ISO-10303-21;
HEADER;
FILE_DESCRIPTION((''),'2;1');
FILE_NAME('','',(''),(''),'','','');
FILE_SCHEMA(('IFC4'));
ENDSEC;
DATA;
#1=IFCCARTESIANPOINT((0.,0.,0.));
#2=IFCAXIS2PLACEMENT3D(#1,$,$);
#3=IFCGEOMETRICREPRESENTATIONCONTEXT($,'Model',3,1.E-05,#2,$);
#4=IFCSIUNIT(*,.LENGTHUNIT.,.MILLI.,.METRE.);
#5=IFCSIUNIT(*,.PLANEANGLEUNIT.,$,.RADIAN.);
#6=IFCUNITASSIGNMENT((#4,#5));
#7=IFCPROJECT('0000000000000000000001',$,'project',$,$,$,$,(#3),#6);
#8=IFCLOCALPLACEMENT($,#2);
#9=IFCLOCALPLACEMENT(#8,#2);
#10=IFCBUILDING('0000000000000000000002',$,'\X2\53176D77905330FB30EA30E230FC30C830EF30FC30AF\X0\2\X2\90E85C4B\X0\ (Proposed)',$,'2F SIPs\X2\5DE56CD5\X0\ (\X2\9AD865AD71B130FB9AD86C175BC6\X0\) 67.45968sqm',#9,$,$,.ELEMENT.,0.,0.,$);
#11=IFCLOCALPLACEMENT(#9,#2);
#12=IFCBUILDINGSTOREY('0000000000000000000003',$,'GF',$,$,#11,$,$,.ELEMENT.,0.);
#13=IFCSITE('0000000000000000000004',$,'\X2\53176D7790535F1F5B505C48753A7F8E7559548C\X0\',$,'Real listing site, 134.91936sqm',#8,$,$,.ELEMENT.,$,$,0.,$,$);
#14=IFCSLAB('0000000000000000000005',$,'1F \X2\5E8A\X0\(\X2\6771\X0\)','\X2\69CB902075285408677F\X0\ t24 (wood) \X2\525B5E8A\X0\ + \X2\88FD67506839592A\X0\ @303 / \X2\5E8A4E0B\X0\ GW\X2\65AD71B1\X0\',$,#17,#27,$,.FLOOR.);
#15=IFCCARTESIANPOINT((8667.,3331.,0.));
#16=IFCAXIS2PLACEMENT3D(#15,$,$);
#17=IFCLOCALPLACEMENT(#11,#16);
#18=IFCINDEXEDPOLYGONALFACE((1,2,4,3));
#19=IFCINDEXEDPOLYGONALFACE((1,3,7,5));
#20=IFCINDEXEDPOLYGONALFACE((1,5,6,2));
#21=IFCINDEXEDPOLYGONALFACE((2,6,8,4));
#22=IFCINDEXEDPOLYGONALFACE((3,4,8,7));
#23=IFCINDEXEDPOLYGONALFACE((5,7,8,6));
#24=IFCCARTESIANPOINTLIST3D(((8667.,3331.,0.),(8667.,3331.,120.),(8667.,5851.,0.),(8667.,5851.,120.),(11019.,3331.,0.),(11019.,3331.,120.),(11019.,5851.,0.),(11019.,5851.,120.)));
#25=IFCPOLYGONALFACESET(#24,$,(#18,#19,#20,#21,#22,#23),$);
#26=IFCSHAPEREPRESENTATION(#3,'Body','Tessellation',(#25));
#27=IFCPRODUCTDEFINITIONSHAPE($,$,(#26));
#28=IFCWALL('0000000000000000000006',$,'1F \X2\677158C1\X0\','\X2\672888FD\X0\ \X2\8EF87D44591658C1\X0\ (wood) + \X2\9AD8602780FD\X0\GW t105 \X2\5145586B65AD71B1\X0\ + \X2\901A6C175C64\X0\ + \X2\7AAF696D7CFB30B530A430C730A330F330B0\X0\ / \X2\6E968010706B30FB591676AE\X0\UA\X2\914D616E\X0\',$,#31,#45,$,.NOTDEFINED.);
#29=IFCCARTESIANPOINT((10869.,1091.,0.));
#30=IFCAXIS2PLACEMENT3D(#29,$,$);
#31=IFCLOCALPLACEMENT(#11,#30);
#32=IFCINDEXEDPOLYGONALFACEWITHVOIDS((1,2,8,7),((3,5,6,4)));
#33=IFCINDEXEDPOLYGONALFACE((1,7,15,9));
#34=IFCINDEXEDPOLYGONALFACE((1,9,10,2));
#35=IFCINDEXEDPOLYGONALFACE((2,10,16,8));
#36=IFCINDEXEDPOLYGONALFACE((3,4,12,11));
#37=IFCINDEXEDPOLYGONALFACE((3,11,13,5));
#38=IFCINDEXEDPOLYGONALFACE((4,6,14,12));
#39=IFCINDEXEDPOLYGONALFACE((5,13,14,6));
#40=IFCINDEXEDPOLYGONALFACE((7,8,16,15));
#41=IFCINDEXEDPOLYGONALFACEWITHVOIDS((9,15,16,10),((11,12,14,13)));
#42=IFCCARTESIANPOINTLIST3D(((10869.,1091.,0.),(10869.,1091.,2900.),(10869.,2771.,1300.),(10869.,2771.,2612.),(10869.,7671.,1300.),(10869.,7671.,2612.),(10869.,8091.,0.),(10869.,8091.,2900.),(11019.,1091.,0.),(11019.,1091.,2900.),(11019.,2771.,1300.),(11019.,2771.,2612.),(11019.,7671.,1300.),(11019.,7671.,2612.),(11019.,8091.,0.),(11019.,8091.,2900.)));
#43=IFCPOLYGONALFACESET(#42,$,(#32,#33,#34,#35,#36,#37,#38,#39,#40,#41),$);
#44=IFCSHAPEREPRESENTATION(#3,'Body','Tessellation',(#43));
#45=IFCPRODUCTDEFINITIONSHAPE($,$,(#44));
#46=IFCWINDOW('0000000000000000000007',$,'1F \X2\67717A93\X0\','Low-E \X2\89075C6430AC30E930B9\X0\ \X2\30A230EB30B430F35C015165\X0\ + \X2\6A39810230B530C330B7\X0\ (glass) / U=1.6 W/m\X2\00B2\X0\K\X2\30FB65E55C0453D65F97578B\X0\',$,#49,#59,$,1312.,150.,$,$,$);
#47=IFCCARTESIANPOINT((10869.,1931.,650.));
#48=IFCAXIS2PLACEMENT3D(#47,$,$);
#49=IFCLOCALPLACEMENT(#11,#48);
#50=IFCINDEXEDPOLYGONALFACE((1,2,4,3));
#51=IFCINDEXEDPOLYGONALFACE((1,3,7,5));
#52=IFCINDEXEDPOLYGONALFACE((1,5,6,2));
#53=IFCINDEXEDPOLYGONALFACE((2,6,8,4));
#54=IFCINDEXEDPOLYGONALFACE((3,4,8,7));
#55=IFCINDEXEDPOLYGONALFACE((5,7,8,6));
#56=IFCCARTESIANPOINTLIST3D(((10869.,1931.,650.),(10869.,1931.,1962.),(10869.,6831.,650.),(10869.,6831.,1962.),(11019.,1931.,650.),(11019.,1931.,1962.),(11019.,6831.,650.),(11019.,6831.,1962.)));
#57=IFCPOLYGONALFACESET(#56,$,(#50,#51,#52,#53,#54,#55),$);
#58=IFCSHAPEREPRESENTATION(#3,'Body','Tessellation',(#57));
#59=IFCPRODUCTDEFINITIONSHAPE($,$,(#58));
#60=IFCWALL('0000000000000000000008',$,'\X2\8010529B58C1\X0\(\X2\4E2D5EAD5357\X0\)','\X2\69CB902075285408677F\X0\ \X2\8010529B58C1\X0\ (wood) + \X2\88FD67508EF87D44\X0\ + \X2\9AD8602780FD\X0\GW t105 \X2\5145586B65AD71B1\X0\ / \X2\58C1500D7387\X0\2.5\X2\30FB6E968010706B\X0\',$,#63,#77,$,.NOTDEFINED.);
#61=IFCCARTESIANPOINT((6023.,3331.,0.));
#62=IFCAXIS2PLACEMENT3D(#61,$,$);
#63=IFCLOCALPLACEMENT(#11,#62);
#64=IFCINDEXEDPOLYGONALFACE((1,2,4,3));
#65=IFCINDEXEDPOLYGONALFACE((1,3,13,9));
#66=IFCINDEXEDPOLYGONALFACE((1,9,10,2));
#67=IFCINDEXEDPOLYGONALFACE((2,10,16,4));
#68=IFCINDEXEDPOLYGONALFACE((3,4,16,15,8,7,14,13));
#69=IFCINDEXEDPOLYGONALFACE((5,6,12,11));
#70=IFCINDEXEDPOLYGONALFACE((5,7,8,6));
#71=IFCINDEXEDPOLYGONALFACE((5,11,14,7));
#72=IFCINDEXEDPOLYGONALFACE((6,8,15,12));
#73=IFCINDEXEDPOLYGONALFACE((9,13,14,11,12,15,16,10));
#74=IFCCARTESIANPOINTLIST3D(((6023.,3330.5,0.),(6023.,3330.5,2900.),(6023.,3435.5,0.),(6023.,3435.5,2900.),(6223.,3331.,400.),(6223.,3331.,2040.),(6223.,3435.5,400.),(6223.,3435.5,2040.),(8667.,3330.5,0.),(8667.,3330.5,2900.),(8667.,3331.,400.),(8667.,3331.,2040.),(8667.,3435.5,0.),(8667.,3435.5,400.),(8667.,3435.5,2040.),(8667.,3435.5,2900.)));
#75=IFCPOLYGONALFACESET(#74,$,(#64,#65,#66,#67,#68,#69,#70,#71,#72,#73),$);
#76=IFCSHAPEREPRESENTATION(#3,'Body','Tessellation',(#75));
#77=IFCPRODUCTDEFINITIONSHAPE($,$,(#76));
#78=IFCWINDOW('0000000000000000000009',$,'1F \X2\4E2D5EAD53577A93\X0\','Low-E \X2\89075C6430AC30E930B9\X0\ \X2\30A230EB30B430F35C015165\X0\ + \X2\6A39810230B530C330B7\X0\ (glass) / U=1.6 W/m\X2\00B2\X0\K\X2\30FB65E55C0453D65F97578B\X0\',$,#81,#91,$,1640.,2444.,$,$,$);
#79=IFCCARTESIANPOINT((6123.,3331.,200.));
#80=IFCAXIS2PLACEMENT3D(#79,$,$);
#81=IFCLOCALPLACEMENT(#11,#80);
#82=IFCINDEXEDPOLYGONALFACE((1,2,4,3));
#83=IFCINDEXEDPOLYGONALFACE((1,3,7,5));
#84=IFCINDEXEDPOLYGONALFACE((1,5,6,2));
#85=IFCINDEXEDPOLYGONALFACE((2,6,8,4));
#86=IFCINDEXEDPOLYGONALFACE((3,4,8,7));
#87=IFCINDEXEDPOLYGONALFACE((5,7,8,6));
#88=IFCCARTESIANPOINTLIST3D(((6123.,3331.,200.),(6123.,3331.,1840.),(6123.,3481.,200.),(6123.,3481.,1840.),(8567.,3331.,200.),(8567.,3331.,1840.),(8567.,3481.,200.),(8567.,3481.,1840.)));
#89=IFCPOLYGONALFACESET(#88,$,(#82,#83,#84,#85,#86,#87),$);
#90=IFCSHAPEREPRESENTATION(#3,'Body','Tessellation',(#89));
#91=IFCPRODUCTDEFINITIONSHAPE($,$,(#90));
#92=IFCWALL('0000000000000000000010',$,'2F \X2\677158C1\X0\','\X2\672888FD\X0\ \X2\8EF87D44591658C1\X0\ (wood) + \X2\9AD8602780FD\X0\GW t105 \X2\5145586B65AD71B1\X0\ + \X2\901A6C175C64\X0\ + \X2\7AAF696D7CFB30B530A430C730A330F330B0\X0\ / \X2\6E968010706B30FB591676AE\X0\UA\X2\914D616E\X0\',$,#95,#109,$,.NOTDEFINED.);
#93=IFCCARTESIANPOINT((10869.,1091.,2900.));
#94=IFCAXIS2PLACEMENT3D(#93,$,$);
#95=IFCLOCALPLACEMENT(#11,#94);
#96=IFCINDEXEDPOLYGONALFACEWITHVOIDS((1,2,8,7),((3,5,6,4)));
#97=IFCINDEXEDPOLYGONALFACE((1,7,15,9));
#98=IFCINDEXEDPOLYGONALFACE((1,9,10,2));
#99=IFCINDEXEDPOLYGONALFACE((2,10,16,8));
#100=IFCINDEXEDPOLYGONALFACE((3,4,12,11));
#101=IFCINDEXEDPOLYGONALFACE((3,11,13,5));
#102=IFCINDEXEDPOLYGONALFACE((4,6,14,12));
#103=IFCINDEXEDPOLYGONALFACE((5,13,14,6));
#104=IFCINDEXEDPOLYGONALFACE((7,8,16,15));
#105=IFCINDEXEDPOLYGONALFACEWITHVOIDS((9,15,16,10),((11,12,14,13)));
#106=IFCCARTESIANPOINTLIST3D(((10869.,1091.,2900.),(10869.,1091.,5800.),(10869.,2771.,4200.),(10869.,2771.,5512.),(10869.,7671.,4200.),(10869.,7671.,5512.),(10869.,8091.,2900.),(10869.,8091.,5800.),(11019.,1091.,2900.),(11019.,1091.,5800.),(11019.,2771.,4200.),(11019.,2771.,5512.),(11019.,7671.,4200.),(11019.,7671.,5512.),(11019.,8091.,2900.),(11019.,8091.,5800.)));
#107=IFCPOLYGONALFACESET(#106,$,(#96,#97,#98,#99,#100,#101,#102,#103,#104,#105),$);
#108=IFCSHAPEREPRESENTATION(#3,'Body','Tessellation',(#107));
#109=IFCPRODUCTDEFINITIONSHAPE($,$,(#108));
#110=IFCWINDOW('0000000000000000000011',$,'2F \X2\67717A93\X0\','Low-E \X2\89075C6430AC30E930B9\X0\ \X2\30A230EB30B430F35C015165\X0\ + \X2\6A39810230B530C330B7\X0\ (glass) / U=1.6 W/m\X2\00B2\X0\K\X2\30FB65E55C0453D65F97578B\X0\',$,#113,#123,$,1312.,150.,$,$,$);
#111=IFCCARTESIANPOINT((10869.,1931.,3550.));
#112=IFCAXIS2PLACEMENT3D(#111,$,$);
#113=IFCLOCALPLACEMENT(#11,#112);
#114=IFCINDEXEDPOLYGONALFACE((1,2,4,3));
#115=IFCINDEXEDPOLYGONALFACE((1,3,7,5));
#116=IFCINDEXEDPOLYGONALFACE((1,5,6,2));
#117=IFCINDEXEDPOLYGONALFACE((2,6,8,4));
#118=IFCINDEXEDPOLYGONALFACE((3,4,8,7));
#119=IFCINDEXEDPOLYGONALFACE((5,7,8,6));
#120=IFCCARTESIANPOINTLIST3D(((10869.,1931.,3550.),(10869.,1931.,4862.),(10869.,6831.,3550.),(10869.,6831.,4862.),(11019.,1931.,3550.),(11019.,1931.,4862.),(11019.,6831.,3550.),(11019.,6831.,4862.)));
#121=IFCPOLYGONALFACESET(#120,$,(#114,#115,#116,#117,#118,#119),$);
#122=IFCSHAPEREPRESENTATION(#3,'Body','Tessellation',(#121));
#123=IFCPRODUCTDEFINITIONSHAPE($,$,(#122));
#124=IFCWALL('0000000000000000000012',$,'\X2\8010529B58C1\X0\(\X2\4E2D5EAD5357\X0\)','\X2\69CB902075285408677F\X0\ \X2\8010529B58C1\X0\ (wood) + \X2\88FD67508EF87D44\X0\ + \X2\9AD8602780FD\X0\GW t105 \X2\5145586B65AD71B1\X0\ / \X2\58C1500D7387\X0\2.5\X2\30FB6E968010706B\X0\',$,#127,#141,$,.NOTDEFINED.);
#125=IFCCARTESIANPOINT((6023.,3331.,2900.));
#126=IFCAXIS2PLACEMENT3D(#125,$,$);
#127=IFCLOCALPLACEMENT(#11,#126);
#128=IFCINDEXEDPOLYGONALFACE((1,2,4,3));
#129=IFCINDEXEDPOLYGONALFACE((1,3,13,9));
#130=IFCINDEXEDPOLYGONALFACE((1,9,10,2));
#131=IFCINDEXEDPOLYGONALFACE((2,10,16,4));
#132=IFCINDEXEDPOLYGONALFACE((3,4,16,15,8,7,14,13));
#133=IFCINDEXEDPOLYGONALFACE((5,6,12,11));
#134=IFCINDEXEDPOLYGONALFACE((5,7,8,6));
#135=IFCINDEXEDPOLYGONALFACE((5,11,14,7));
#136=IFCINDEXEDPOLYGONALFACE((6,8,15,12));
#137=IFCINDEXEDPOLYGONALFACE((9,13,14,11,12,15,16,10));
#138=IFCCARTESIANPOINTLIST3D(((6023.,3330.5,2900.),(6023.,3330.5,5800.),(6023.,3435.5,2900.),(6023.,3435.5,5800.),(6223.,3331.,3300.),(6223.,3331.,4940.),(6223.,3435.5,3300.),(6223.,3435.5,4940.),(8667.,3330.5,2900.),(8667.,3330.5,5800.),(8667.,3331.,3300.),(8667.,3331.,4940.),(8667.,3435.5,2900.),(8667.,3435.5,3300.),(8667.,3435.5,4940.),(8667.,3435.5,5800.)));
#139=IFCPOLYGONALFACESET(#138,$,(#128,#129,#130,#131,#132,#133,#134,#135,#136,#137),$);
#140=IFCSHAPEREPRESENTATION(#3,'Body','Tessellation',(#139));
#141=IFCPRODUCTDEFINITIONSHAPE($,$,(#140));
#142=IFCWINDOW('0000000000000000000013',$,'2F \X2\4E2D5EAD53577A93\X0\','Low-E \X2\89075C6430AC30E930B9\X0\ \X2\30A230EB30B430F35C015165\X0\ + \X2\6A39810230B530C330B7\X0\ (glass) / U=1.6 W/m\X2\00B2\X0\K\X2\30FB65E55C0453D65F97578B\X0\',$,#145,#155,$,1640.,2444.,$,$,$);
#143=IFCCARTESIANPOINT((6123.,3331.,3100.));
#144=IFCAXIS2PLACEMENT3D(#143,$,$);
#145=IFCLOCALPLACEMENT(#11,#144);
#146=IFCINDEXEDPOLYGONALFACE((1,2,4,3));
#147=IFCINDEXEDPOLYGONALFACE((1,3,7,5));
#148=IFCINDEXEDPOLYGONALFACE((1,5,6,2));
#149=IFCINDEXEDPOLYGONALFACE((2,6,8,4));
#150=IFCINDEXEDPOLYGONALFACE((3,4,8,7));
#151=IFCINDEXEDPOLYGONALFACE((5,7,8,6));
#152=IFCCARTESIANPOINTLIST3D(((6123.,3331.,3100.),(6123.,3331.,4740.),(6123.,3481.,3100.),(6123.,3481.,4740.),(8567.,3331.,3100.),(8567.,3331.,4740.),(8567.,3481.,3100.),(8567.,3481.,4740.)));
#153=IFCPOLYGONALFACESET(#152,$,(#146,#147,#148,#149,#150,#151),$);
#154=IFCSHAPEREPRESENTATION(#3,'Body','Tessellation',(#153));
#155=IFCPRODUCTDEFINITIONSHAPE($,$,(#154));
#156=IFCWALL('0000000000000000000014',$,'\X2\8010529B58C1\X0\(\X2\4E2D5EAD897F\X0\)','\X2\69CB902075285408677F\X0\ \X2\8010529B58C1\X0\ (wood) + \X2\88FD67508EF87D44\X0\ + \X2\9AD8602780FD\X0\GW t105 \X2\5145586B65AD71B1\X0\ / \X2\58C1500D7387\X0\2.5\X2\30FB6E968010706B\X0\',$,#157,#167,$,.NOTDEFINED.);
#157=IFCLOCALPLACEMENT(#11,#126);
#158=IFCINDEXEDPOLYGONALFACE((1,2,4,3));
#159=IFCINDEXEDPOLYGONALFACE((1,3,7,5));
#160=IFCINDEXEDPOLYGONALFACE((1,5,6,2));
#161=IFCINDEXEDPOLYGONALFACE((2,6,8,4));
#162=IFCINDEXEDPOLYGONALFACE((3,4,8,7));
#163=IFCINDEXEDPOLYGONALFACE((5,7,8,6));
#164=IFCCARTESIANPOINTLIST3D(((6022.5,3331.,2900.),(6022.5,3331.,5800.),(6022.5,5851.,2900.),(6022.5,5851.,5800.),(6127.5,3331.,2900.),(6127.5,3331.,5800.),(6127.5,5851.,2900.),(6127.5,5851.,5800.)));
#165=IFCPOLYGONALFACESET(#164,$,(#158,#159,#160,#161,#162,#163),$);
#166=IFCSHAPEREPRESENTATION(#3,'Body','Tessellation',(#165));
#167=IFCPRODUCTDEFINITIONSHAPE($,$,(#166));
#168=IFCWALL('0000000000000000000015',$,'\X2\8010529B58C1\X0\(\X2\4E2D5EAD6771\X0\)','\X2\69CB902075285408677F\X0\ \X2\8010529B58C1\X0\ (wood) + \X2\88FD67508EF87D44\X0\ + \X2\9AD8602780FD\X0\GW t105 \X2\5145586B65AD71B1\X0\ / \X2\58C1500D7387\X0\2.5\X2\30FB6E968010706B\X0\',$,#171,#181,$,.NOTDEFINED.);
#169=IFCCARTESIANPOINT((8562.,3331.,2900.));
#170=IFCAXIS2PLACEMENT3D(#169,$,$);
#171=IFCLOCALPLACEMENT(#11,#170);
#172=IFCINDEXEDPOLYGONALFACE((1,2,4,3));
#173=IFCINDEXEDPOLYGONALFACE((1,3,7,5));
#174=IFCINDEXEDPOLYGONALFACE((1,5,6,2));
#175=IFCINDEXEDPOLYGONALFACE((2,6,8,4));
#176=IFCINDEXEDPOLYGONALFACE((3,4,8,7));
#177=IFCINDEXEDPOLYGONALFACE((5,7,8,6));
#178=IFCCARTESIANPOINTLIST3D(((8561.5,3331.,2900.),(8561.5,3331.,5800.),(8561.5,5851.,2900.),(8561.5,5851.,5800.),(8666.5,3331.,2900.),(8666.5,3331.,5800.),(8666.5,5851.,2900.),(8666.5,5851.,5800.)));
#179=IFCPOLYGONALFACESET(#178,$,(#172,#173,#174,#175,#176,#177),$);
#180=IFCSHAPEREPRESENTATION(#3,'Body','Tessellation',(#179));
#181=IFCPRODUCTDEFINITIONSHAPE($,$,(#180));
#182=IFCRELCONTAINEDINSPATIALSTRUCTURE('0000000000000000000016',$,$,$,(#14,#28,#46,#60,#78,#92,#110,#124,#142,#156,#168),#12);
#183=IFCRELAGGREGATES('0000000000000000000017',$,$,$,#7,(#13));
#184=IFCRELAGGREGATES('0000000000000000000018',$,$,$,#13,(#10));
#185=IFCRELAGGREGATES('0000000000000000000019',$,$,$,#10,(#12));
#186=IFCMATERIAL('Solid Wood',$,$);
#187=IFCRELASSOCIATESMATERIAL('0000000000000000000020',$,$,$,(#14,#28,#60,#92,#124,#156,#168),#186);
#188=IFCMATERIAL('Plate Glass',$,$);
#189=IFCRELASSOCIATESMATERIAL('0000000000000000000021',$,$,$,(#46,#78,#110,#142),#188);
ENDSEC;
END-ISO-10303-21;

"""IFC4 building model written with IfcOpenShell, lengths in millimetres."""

from ifc_helpers import new_model, si_unit, frame, frame_2d, origin, place, context, project, spatial, rectangle, extrude, material, element, fill, save


model = new_model("IFC4")

# Units and contexts
model_context = context("Model", 3, precision=1e-05, world=origin())
ifc_project = project(units=[si_unit("LENGTHUNIT", "METRE", prefix="MILLI"), si_unit("PLANEANGLEUNIT", "RADIAN")], contexts=[model_context])

# Site, building, storey
site_placement = place(None, origin())
site = spatial("IfcSite", under=ifc_project, at=site_placement, Name="北海道弟子屈町美留和", ObjectType="Real listing site, 134.91936sqm", CompositionType="ELEMENT", RefElevation=0.0)
building_placement = place(site_placement, origin())
building = spatial("IfcBuilding", under=site, at=building_placement, Name="北海道・リモートワーク2部屋 (Proposed)", ObjectType="2F SIPs工法 (高断熱・高気密) 67.45968sqm", CompositionType="ELEMENT", ElevationOfRefHeight=0.0, ElevationOfTerrain=0.0)
storey_placement = place(building_placement, origin())
storey = spatial("IfcBuildingStorey", under=building, at=storey_placement, Name="GF", CompositionType="ELEMENT", Elevation=0.0)

# Slab
ifc_material_1 = material(Name="Solid Wood")
slab_placement = place(storey_placement, frame((8667.0, 3331.0, 0.0)))
element("IfcSlab", 1, at=slab_placement, inside=storey, material=ifc_material_1, Name="1F 床(東)", Description="構造用合板 t24 (wood) 剛床 + 製材根太 @303 / 床下 GW断熱", PredefinedType="FLOOR", context=model_context, shape_type="SweptSolid", body=[
    extrude(rectangle(XDim=2352.0, YDim=2520.0, at=frame_2d((1176.0, 1260.0))), frame((8667.0, 3331.0, 0.0)), (0.0, 0.0, 1.0), 120.0),
])

# Walls, openings, windows
wall_1_placement = place(storey_placement, frame((10869.0, 1091.0, 0.0)))
wall_1 = element("IfcWall", 2, at=wall_1_placement, inside=storey, material=ifc_material_1, Name="1F 東壁", Description="木製 軸組外壁 (wood) + 高性能GW t105 充填断熱 + 通気層 + 窯業系サイディング / 準耐火・外皮UA配慮", PredefinedType="NOTDEFINED", context=model_context, shape_type="SweptSolid", body=[
    extrude(rectangle(XDim=150.0, YDim=7000.0, at=frame_2d((75.0, 3500.0))), frame((10869.0, 1091.0, 0.0)), (0.0, 0.0, 1.0), 2900.0),
])
opening_1_placement = place(storey_placement, frame((10869.0, 1931.0, 650.0)))
opening_1 = element("IfcOpeningElement", 3, at=opening_1_placement, cuts=wall_1, PredefinedType="NOTDEFINED", context=model_context, shape_type="SweptSolid", body=[
    extrude(rectangle(XDim=150.0, YDim=4900.0, at=frame_2d((75.0, 2450.0))), frame((10869.0, 1931.0, 650.0)), (0.0, 0.0, 1.0), 1312.0),
])
ifc_material_2 = material(Name="Plate Glass")
window_1_placement = place(storey_placement, frame((10869.0, 1931.0, 650.0)))
window_1 = element("IfcWindow", 4, at=window_1_placement, inside=storey, material=ifc_material_2, Name="1F 東窓", Description="Low-E 複層ガラス アルゴン封入 + 樹脂サッシ (glass) / U=1.6 W/m²K・日射取得型", OverallHeight=1312.0, OverallWidth=150.0, context=model_context, shape_type="SweptSolid", body=[
    extrude(rectangle(XDim=150.0, YDim=4900.0, at=frame_2d((75.0, 2450.0))), frame((10869.0, 1931.0, 650.0)), (0.0, 0.0, 1.0), 1312.0),
])
fill(opening_1, window_1)
wall_2_placement = place(storey_placement, frame((6023.0, 3331.0, 0.0)))
wall_2 = element("IfcWall", 5, at=wall_2_placement, inside=storey, material=ifc_material_1, Name="耐力壁(中庭南)", Description="構造用合板 耐力壁 (wood) + 製材軸組 + 高性能GW t105 充填断熱 / 壁倍率2.5・準耐火", PredefinedType="NOTDEFINED", context=model_context, shape_type="SweptSolid", body=[
    extrude(rectangle(XDim=2644.0, YDim=105.0, at=frame_2d((1322.0, 52.0))), frame((6023.0, 3331.0, 0.0)), (0.0, 0.0, 1.0), 2900.0),
])
opening_2_placement = place(storey_placement, frame((6123.0, 3331.0, 200.0)))
opening_2 = element("IfcOpeningElement", 6, at=opening_2_placement, cuts=wall_2, PredefinedType="NOTDEFINED", context=model_context, shape_type="SweptSolid", body=[
    extrude(rectangle(XDim=2444.0, YDim=150.0, at=frame_2d((1222.0, 75.0))), frame((6123.0, 3331.0, 200.0)), (0.0, 0.0, 1.0), 1640.0),
])
window_2_placement = place(storey_placement, frame((6123.0, 3331.0, 200.0)))
window_2 = element("IfcWindow", 7, at=window_2_placement, inside=storey, material=ifc_material_2, Name="1F 中庭南窓", Description="Low-E 複層ガラス アルゴン封入 + 樹脂サッシ (glass) / U=1.6 W/m²K・日射取得型", OverallHeight=1640.0, OverallWidth=2444.0, context=model_context, shape_type="SweptSolid", body=[
    extrude(rectangle(XDim=2444.0, YDim=150.0, at=frame_2d((1222.0, 75.0))), frame((6123.0, 3331.0, 200.0)), (0.0, 0.0, 1.0), 1640.0),
])
fill(opening_2, window_2)

# Walls, openings, windows
wall_3_placement = place(storey_placement, frame((10869.0, 1091.0, 2900.0)))
wall_3 = element("IfcWall", 8, at=wall_3_placement, inside=storey, material=ifc_material_1, Name="2F 東壁", Description="木製 軸組外壁 (wood) + 高性能GW t105 充填断熱 + 通気層 + 窯業系サイディング / 準耐火・外皮UA配慮", PredefinedType="NOTDEFINED", context=model_context, shape_type="SweptSolid", body=[
    extrude(rectangle(XDim=150.0, YDim=7000.0, at=frame_2d((75.0, 3500.0))), frame((10869.0, 1091.0, 2900.0)), (0.0, 0.0, 1.0), 2900.0),
])
opening_3_placement = place(storey_placement, frame((10869.0, 1931.0, 3550.0)))
opening_3 = element("IfcOpeningElement", 9, at=opening_3_placement, cuts=wall_3, PredefinedType="NOTDEFINED", context=model_context, shape_type="SweptSolid", body=[
    extrude(rectangle(XDim=150.0, YDim=4900.0, at=frame_2d((75.0, 2450.0))), frame((10869.0, 1931.0, 3550.0)), (0.0, 0.0, 1.0), 1312.0),
])
window_3_placement = place(storey_placement, frame((10869.0, 1931.0, 3550.0)))
window_3 = element("IfcWindow", 10, at=window_3_placement, inside=storey, material=ifc_material_2, Name="2F 東窓", Description="Low-E 複層ガラス アルゴン封入 + 樹脂サッシ (glass) / U=1.6 W/m²K・日射取得型", OverallHeight=1312.0, OverallWidth=150.0, context=model_context, shape_type="SweptSolid", body=[
    extrude(rectangle(XDim=150.0, YDim=4900.0, at=frame_2d((75.0, 2450.0))), frame((10869.0, 1931.0, 3550.0)), (0.0, 0.0, 1.0), 1312.0),
])
fill(opening_3, window_3)
wall_4_placement = place(storey_placement, frame((6023.0, 3331.0, 2900.0)))
wall_4 = element("IfcWall", 11, at=wall_4_placement, inside=storey, material=ifc_material_1, Name="耐力壁(中庭南)", Description="構造用合板 耐力壁 (wood) + 製材軸組 + 高性能GW t105 充填断熱 / 壁倍率2.5・準耐火", PredefinedType="NOTDEFINED", context=model_context, shape_type="SweptSolid", body=[
    extrude(rectangle(XDim=2644.0, YDim=105.0, at=frame_2d((1322.0, 52.0))), frame((6023.0, 3331.0, 2900.0)), (0.0, 0.0, 1.0), 2900.0),
])
opening_4_placement = place(storey_placement, frame((6123.0, 3331.0, 3100.0)))
opening_4 = element("IfcOpeningElement", 12, at=opening_4_placement, cuts=wall_4, PredefinedType="NOTDEFINED", context=model_context, shape_type="SweptSolid", body=[
    extrude(rectangle(XDim=2444.0, YDim=150.0, at=frame_2d((1222.0, 75.0))), frame((6123.0, 3331.0, 3100.0)), (0.0, 0.0, 1.0), 1640.0),
])
window_4_placement = place(storey_placement, frame((6123.0, 3331.0, 3100.0)))
window_4 = element("IfcWindow", 13, at=window_4_placement, inside=storey, material=ifc_material_2, Name="2F 中庭南窓", Description="Low-E 複層ガラス アルゴン封入 + 樹脂サッシ (glass) / U=1.6 W/m²K・日射取得型", OverallHeight=1640.0, OverallWidth=2444.0, context=model_context, shape_type="SweptSolid", body=[
    extrude(rectangle(XDim=2444.0, YDim=150.0, at=frame_2d((1222.0, 75.0))), frame((6123.0, 3331.0, 3100.0)), (0.0, 0.0, 1.0), 1640.0),
])
fill(opening_4, window_4)

# Walls
wall_5_placement = place(storey_placement, frame((6023.0, 3331.0, 2900.0)))
element("IfcWall", 14, at=wall_5_placement, inside=storey, material=ifc_material_1, Name="耐力壁(中庭西)", Description="構造用合板 耐力壁 (wood) + 製材軸組 + 高性能GW t105 充填断熱 / 壁倍率2.5・準耐火", PredefinedType="NOTDEFINED", context=model_context, shape_type="SweptSolid", body=[
    extrude(rectangle(XDim=105.0, YDim=2520.0, at=frame_2d((52.0, 1260.0))), frame((6023.0, 3331.0, 2900.0)), (0.0, 0.0, 1.0), 2900.0),
])
wall_6_placement = place(storey_placement, frame((8562.0, 3331.0, 2900.0)))
element("IfcWall", 15, at=wall_6_placement, inside=storey, material=ifc_material_1, Name="耐力壁(中庭東)", Description="構造用合板 耐力壁 (wood) + 製材軸組 + 高性能GW t105 充填断熱 / 壁倍率2.5・準耐火", PredefinedType="NOTDEFINED", context=model_context, shape_type="SweptSolid", body=[
    extrude(rectangle(XDim=105.0, YDim=2520.0, at=frame_2d((52.0, 1260.0))), frame((8562.0, 3331.0, 2900.0)), (0.0, 0.0, 1.0), 2900.0),
])

save(model, "model.ifc")
